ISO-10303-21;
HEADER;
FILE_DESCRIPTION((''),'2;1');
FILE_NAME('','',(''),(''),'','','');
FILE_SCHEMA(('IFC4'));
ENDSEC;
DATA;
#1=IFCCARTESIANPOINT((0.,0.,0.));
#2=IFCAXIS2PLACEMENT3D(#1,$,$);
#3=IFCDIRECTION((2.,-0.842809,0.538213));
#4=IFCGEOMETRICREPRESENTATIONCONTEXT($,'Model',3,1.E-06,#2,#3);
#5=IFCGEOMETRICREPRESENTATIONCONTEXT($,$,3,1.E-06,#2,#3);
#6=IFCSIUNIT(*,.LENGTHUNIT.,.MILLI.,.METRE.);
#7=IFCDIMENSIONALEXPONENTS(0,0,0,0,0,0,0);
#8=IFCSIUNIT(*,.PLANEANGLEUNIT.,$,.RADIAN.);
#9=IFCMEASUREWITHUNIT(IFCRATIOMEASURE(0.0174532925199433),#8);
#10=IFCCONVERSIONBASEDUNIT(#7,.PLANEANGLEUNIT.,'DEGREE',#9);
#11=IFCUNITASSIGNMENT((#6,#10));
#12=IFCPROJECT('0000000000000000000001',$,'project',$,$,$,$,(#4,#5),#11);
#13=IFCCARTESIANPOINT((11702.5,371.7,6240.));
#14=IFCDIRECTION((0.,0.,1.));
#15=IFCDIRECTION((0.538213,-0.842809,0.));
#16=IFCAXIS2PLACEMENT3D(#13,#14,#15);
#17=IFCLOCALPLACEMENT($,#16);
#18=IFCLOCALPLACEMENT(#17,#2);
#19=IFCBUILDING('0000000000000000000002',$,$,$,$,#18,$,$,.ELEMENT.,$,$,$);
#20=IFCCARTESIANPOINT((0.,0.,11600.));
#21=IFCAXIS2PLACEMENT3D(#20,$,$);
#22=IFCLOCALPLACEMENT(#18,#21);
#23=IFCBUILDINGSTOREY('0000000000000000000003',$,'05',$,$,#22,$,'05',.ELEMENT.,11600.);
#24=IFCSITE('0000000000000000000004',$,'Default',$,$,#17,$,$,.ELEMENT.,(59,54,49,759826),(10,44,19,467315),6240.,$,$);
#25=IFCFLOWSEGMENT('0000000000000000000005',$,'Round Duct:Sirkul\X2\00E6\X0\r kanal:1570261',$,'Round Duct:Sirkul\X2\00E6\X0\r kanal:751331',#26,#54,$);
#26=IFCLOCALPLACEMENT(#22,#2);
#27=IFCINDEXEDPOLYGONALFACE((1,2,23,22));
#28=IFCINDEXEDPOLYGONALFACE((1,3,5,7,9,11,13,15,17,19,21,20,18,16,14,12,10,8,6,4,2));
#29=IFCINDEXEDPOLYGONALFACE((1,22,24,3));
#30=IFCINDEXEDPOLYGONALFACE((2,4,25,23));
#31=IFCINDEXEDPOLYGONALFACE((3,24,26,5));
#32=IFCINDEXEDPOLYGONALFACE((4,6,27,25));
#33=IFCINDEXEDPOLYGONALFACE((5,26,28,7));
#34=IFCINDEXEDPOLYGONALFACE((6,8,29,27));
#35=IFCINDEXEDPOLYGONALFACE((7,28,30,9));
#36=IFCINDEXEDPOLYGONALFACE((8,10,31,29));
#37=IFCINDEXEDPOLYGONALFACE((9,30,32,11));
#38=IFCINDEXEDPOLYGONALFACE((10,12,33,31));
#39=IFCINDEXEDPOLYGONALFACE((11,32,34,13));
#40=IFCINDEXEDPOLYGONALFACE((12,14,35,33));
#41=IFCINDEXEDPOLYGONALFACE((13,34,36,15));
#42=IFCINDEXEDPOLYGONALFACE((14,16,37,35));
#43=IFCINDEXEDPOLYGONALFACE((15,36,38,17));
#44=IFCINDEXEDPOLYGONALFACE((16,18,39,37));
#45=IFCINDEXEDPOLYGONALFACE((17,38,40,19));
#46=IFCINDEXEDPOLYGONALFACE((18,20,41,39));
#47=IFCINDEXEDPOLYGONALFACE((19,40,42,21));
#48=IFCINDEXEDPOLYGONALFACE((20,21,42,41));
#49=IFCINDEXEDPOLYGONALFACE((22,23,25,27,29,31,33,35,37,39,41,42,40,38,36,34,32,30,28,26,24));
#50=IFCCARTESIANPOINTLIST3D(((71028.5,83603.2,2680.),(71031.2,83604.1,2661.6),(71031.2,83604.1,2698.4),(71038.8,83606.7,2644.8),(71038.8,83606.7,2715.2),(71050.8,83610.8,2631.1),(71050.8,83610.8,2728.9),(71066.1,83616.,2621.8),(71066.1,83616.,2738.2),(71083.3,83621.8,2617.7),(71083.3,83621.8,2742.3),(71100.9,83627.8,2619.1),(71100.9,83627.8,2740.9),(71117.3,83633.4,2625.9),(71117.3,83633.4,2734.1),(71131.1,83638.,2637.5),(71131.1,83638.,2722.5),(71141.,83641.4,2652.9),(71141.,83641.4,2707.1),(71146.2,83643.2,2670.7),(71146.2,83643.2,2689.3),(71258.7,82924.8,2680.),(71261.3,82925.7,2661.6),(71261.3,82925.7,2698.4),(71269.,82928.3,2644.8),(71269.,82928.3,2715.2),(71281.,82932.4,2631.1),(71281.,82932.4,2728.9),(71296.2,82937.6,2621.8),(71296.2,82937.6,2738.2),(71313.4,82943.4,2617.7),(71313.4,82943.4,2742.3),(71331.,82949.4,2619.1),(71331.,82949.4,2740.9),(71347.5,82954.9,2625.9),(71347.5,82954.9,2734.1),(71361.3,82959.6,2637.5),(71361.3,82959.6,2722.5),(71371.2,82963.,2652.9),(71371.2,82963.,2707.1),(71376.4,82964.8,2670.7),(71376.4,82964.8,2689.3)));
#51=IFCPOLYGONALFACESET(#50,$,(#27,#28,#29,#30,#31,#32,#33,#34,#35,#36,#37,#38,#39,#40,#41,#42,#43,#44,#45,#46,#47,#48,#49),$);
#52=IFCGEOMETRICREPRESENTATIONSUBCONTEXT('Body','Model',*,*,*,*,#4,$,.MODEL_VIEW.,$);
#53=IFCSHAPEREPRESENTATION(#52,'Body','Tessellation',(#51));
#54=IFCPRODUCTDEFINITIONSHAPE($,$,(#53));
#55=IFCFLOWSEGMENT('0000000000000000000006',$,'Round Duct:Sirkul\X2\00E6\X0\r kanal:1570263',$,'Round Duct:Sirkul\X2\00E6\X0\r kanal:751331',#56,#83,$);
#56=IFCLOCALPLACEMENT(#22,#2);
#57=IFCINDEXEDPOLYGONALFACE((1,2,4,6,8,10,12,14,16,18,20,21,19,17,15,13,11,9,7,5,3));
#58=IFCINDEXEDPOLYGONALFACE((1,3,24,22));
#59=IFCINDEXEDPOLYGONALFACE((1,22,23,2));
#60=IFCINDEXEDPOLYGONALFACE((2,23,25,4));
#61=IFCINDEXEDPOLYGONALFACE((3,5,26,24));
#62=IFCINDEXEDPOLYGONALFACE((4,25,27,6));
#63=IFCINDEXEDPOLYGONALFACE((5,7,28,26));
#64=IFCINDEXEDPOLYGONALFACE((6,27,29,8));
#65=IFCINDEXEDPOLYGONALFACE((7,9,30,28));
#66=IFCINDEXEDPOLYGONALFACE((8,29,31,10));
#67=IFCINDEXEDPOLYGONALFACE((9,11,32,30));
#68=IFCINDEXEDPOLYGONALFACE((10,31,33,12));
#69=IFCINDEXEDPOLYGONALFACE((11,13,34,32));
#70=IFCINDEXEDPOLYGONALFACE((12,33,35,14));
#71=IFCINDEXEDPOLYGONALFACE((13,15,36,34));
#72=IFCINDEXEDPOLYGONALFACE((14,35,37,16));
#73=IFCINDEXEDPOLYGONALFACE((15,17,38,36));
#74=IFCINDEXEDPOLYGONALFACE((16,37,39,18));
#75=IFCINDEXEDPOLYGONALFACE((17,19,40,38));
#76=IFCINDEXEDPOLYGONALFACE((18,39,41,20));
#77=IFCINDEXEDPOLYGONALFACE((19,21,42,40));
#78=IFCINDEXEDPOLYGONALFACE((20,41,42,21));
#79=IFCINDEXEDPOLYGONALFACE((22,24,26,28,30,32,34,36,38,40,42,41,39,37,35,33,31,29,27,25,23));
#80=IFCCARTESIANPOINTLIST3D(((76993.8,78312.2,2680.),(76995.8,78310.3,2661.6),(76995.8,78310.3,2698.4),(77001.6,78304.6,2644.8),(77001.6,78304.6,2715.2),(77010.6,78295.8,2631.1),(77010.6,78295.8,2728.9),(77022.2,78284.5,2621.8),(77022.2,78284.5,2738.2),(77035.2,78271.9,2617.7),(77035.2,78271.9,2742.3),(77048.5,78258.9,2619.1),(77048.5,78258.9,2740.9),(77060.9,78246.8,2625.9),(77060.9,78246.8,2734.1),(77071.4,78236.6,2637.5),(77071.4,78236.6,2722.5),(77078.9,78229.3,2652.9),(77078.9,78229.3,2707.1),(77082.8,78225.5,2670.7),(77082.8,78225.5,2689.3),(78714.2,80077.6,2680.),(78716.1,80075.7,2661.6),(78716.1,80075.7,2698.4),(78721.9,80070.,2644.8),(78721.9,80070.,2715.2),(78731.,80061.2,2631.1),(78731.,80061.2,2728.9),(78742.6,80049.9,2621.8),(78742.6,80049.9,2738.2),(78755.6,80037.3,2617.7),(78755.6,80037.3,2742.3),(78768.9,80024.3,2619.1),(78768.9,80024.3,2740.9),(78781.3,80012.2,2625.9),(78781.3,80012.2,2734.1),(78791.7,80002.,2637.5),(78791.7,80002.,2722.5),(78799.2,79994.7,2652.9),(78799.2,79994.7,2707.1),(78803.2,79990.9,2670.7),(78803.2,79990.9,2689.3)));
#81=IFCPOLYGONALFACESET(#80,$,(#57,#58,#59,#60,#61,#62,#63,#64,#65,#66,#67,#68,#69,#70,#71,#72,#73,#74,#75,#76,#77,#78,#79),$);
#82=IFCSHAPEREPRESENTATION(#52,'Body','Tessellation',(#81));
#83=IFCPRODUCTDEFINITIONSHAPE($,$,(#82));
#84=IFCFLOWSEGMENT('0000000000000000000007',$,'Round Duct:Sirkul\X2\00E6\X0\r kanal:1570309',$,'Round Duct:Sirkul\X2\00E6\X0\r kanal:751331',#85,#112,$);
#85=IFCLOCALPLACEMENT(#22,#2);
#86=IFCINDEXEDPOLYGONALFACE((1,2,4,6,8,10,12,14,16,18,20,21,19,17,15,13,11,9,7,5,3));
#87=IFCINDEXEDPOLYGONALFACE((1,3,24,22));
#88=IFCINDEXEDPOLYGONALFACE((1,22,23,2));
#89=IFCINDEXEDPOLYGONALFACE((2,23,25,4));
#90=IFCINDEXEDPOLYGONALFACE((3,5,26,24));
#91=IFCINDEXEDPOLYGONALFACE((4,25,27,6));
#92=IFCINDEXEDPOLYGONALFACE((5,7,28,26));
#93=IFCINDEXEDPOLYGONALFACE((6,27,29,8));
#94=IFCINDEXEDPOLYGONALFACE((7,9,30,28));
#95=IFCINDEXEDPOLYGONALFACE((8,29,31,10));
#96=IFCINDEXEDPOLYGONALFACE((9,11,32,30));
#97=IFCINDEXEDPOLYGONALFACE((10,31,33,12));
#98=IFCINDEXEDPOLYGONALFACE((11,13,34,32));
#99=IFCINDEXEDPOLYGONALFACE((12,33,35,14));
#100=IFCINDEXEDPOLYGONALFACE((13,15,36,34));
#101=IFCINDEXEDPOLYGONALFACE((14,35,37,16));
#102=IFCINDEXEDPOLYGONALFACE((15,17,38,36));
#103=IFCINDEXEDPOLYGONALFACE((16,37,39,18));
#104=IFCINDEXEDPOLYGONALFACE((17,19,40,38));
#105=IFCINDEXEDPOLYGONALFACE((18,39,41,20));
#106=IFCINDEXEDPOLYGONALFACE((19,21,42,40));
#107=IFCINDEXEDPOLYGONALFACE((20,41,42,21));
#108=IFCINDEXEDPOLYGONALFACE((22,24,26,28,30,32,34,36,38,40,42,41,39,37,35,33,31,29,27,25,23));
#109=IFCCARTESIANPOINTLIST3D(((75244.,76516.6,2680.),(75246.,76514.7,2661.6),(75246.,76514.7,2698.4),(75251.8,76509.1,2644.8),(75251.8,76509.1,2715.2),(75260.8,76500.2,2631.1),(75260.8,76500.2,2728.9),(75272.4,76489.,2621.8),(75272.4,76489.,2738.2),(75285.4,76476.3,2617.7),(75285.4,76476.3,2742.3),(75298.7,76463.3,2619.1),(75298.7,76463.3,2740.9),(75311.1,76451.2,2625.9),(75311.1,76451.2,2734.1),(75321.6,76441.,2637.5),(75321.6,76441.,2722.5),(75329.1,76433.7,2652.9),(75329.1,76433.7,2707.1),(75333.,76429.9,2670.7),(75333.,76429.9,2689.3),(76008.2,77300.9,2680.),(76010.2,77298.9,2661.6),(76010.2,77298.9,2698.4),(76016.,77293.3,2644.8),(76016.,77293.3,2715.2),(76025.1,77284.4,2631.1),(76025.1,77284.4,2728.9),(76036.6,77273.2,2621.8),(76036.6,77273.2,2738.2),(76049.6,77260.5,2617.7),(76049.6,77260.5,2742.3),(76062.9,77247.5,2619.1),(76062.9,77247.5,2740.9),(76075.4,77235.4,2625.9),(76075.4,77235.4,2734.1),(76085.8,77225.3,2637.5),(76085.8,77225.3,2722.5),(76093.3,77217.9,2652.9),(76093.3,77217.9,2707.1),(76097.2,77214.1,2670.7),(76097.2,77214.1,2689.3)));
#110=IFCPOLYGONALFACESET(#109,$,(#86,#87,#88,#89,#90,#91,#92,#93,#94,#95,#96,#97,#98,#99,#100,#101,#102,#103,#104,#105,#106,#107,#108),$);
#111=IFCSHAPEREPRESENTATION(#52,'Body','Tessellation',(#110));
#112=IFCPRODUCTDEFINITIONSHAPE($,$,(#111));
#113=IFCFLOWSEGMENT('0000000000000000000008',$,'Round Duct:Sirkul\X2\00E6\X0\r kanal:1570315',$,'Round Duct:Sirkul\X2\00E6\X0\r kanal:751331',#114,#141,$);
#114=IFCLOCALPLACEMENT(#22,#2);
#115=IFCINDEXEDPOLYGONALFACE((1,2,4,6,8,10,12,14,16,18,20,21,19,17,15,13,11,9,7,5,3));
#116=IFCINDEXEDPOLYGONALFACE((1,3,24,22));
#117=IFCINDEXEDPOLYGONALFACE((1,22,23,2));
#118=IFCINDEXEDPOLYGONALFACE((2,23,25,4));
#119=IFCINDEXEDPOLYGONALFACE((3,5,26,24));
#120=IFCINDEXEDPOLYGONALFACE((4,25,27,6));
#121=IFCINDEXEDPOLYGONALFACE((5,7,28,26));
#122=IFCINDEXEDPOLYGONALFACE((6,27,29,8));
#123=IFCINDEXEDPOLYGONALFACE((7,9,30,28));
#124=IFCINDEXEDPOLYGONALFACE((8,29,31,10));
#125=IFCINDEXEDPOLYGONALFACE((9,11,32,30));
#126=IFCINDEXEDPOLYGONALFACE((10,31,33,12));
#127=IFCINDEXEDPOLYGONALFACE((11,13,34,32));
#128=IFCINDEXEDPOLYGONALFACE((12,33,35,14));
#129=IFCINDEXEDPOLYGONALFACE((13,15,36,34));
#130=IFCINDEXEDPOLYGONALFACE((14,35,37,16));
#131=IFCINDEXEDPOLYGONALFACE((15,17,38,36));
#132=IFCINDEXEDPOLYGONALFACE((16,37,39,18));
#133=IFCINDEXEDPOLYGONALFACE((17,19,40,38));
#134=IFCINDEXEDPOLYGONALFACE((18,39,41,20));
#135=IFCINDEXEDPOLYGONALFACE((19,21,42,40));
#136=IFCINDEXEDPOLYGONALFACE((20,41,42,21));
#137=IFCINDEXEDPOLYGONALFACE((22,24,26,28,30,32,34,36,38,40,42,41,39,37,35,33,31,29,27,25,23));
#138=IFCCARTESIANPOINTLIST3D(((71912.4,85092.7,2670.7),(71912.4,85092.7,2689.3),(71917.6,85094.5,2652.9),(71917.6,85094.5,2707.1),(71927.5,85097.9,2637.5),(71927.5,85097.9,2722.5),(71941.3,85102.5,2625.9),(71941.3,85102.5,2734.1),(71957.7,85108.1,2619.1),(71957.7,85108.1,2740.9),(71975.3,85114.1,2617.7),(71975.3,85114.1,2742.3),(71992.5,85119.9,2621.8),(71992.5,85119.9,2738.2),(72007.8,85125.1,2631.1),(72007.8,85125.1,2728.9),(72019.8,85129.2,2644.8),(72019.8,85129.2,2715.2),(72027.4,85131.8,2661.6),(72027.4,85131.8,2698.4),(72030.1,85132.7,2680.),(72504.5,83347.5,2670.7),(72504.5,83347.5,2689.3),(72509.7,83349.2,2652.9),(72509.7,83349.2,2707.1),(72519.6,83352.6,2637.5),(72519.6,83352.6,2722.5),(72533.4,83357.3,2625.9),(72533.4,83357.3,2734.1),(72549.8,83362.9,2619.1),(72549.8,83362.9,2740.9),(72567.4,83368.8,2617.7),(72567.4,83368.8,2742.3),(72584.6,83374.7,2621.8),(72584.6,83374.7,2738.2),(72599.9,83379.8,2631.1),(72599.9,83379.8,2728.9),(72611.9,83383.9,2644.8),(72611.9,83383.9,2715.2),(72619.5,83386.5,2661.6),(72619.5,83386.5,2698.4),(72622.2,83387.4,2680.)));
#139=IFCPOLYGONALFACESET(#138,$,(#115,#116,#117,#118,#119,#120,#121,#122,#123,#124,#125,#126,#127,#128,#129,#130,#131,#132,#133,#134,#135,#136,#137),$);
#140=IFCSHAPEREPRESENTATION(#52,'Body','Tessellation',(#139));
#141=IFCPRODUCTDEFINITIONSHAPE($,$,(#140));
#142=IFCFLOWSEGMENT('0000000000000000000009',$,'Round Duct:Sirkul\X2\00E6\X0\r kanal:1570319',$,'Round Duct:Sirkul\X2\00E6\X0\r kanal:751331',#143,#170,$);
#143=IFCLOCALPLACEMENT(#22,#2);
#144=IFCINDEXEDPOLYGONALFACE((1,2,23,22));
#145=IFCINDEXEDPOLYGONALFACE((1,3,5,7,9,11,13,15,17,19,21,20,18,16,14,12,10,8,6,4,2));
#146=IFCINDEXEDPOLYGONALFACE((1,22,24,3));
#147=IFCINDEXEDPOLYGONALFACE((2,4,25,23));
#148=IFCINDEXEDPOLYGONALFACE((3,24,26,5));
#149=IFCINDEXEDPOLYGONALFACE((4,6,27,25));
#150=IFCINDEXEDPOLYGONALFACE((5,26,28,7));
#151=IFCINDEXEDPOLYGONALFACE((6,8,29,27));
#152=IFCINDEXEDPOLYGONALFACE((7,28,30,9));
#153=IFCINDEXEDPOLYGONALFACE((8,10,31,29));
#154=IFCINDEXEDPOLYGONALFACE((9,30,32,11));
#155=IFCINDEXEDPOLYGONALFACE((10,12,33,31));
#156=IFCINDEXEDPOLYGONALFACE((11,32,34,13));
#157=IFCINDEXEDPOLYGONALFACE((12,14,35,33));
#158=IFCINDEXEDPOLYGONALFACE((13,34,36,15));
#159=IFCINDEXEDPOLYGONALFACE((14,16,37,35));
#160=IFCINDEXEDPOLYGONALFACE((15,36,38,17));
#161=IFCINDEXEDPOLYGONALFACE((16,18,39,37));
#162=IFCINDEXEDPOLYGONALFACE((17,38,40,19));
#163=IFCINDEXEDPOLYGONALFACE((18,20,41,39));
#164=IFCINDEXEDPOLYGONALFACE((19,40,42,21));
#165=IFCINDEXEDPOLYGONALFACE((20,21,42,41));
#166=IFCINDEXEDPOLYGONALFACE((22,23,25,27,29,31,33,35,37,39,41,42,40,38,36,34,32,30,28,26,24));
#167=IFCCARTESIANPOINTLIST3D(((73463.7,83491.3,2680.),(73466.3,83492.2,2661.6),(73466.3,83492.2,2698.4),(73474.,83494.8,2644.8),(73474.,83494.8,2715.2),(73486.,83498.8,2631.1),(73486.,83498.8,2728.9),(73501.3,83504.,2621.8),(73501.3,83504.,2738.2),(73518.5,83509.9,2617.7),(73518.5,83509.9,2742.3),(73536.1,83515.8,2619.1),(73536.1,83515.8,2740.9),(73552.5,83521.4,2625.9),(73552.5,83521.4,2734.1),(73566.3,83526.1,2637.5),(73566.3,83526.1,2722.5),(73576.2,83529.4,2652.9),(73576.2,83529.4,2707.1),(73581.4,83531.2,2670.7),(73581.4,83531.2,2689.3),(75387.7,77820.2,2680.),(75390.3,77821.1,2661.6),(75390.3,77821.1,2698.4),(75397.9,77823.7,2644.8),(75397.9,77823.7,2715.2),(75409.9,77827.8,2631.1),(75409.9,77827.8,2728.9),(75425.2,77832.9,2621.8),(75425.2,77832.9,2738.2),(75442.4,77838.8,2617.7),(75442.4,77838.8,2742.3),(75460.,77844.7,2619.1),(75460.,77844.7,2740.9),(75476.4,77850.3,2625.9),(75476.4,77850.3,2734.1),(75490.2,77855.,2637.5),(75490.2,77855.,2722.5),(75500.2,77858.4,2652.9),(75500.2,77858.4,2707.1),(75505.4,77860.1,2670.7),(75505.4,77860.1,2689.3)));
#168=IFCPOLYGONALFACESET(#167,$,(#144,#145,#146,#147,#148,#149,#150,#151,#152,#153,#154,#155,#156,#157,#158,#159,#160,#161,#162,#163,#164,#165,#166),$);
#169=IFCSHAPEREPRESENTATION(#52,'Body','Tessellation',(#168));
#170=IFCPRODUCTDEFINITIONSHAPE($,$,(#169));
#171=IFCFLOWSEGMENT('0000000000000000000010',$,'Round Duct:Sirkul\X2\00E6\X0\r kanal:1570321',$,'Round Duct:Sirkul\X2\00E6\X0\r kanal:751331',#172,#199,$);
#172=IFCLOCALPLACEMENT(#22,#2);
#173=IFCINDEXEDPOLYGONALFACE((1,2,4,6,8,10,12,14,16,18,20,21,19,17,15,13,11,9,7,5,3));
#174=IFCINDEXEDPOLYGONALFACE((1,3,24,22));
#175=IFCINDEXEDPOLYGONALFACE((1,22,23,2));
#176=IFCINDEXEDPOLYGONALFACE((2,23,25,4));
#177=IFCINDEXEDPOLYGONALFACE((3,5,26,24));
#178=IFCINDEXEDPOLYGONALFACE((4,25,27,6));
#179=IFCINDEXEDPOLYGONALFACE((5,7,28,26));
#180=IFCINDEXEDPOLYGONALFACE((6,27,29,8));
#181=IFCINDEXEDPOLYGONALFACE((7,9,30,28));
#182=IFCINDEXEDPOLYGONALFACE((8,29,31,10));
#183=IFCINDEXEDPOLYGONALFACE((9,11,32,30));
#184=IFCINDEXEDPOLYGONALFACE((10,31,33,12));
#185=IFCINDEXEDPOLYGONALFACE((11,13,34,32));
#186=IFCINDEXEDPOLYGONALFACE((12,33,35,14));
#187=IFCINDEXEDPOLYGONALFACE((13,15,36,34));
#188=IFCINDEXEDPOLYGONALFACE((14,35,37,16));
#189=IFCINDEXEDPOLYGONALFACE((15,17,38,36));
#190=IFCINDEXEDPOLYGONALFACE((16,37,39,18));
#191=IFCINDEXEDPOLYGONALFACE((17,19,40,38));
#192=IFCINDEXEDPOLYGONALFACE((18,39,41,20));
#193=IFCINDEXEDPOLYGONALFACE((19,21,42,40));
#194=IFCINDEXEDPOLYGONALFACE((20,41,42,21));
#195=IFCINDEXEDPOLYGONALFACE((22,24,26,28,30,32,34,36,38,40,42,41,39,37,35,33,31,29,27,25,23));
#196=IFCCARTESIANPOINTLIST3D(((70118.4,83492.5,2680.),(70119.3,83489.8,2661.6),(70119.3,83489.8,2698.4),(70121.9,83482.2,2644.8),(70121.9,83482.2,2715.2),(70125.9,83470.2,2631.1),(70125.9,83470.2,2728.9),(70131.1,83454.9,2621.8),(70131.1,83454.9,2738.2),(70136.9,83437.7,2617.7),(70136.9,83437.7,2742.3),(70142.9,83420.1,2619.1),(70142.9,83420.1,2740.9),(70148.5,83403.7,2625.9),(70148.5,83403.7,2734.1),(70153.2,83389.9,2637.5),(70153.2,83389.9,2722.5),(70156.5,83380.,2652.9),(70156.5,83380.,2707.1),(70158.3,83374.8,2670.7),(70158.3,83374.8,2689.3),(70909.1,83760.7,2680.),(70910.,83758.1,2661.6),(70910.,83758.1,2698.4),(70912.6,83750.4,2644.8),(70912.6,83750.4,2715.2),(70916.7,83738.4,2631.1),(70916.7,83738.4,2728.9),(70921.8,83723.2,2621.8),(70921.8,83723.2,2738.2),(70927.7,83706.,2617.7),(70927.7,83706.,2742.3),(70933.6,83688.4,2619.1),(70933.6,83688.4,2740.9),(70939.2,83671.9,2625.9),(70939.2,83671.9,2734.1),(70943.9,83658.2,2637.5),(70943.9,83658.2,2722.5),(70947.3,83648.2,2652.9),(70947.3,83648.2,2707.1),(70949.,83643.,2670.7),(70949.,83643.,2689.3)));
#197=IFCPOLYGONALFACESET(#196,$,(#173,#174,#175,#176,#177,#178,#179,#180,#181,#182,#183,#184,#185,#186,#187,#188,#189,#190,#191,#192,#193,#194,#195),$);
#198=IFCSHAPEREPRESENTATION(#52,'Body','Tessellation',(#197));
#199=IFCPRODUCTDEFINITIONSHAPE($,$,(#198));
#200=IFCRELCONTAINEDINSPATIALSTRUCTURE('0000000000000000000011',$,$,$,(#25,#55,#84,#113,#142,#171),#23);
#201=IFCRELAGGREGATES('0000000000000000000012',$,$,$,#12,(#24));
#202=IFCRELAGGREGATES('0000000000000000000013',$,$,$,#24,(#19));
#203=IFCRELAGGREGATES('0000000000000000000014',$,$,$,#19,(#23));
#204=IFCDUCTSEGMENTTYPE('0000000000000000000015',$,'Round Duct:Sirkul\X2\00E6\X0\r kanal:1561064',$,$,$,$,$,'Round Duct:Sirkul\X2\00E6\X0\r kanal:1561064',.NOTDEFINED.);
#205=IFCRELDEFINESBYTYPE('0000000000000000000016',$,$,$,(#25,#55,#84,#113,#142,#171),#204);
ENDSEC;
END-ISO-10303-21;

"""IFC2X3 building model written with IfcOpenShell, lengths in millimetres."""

from ifc_helpers import new_model, entity, si_unit, converted_unit, direction, frame, frame_2d, origin, origin_2d_with_axis, place, context, subcontext, project, spatial, circle, extrude, type_object, element, save


model = new_model("IFC2X3")

# Units and contexts
model_context = context("Model", 3, precision=1e-06, world=origin(), true_north=direction((2.0, -0.842809, 0.538213)))
context_of_model = context(None, 3, precision=1e-06, world=origin(), true_north=direction((2.0, -0.842809, 0.538213)))
body_context = subcontext(model_context, "Body", "Model", "MODEL_VIEW")
ifc_project = project(units=[si_unit("LENGTHUNIT", "METRE", prefix="MILLI"), converted_unit("PLANEANGLEUNIT", "DEGREE", entity("IfcRatioMeasure", 0.0174532925199433), si_unit("PLANEANGLEUNIT", "RADIAN"), dimensions=[0, 0, 0, 0, 0, 0, 0])], contexts=[model_context, context_of_model])

# Site, building, storey
site_placement = place(None, frame((11702.5, 371.7, 6240.0), z_axis=(0.0, 0.0, 1.0), x_axis=(0.538213, -0.842809, 0.0)))
site = spatial("IfcSite", under=ifc_project, at=site_placement, Name="Default", CompositionType="ELEMENT", RefLatitude=(59, 54, 49, 759826), RefLongitude=(10, 44, 19, 467315), RefElevation=6240.0)
building_placement = place(site_placement, origin())
building = spatial("IfcBuilding", under=site, at=building_placement, CompositionType="ELEMENT")
storey_placement = place(building_placement, frame((0.0, 0.0, 11600.0)))
storey = spatial("IfcBuildingStorey", under=building, at=storey_placement, Name="05", LongName="05", CompositionType="ELEMENT", Elevation=11600.0)

# Flow segments
duct_segment_type = type_object("IfcDuctSegmentType", Name="Round Duct:Sirkulær kanal:1561064", ElementType="Round Duct:Sirkulær kanal:1561064", PredefinedType="NOTDEFINED")
flow_segment_1_placement = place(storey_placement, origin())
element("IfcFlowSegment", 1, at=flow_segment_1_placement, inside=storey, type_object=duct_segment_type, Name="Round Duct:Sirkulær kanal:1570261", ObjectType="Round Duct:Sirkulær kanal:751331", context=body_context, shape_type="SweptSolid", body=[
    extrude(circle(Radius=62.5, at=origin_2d_with_axis()), frame((71087.7, 83623.3, 2680.0), z_axis=(0.321274, -0.946986, 0.0), x_axis=(-0.946986, -0.321274, 0.0)), (0.0, 0.0, 1.0), 716.4),
])
flow_segment_2_placement = place(storey_placement, origin())
element("IfcFlowSegment", 2, at=flow_segment_2_placement, inside=storey, type_object=duct_segment_type, Name="Round Duct:Sirkulær kanal:1570263", ObjectType="Round Duct:Sirkulær kanal:751331", context=body_context, shape_type="SweptSolid", body=[
    extrude(circle(Radius=62.5, at=frame_2d((0.0, 0.0), x_axis=(1.0, 0.0))), frame((77038.5, 78268.6, 2680.0), z_axis=(0.697915, 0.71618, 0.0), x_axis=(-0.71618, 0.697915, 0.0)), (0.0, 0.0, 1.0), 2465.0),
])
flow_segment_3_placement = place(storey_placement, origin())
element("IfcFlowSegment", 3, at=flow_segment_3_placement, inside=storey, type_object=duct_segment_type, Name="Round Duct:Sirkulær kanal:1570309", ObjectType="Round Duct:Sirkulær kanal:751331", context=body_context, shape_type="SweptSolid", body=[
    extrude(circle(Radius=62.5, at=origin_2d_with_axis()), frame((75288.8, 76473.0, 2680.0), z_axis=(0.697915, 0.71618, 0.0), x_axis=(-0.71618, 0.697915, 0.0)), (0.0, 0.0, 1.0), 1095.0),
])
flow_segment_4_placement = place(storey_placement, origin())
element("IfcFlowSegment", 4, at=flow_segment_4_placement, inside=storey, type_object=duct_segment_type, Name="Round Duct:Sirkulær kanal:1570315", ObjectType="Round Duct:Sirkulær kanal:751331", context=body_context, shape_type="SweptSolid", body=[
    extrude(circle(Radius=62.5, at=frame_2d((0.0, 0.0), x_axis=(1.0, 0.0))), frame((71970.9, 85112.6, 2680.0), z_axis=(0.321274, -0.946986, 0.0), x_axis=(0.946986, 0.321274, 0.0)), (0.0, 0.0, 1.0), 1842.9),
])
flow_segment_5_placement = place(storey_placement, origin())
element("IfcFlowSegment", 5, at=flow_segment_5_placement, inside=storey, type_object=duct_segment_type, Name="Round Duct:Sirkulær kanal:1570319", ObjectType="Round Duct:Sirkulær kanal:751331", context=body_context, shape_type="SweptSolid", body=[
    extrude(circle(Radius=62.5, at=frame_2d((0.0, 0.0), x_axis=(1.0, 0.0))), frame((73522.9, 83511.4, 2680.0), z_axis=(0.321274, -0.946986, 0.0), x_axis=(-0.946986, -0.321274, 0.0)), (0.0, 0.0, 1.0), 5988.6),
])
flow_segment_6_placement = place(storey_placement, origin())
element("IfcFlowSegment", 6, at=flow_segment_6_placement, inside=storey, type_object=duct_segment_type, Name="Round Duct:Sirkulær kanal:1570321", ObjectType="Round Duct:Sirkulær kanal:751331", context=body_context, shape_type="SweptSolid", body=[
    extrude(circle(Radius=62.5, at=frame_2d((0.0, 0.0), x_axis=(1.0, 0.0))), frame((70138.4, 83433.3, 2680.0), z_axis=(0.946986, 0.321274, 0.0), x_axis=(-0.321274, 0.946986, 0.0)), (0.0, 0.0, 1.0), 835.0),
])

save(model, "model.ifc")
